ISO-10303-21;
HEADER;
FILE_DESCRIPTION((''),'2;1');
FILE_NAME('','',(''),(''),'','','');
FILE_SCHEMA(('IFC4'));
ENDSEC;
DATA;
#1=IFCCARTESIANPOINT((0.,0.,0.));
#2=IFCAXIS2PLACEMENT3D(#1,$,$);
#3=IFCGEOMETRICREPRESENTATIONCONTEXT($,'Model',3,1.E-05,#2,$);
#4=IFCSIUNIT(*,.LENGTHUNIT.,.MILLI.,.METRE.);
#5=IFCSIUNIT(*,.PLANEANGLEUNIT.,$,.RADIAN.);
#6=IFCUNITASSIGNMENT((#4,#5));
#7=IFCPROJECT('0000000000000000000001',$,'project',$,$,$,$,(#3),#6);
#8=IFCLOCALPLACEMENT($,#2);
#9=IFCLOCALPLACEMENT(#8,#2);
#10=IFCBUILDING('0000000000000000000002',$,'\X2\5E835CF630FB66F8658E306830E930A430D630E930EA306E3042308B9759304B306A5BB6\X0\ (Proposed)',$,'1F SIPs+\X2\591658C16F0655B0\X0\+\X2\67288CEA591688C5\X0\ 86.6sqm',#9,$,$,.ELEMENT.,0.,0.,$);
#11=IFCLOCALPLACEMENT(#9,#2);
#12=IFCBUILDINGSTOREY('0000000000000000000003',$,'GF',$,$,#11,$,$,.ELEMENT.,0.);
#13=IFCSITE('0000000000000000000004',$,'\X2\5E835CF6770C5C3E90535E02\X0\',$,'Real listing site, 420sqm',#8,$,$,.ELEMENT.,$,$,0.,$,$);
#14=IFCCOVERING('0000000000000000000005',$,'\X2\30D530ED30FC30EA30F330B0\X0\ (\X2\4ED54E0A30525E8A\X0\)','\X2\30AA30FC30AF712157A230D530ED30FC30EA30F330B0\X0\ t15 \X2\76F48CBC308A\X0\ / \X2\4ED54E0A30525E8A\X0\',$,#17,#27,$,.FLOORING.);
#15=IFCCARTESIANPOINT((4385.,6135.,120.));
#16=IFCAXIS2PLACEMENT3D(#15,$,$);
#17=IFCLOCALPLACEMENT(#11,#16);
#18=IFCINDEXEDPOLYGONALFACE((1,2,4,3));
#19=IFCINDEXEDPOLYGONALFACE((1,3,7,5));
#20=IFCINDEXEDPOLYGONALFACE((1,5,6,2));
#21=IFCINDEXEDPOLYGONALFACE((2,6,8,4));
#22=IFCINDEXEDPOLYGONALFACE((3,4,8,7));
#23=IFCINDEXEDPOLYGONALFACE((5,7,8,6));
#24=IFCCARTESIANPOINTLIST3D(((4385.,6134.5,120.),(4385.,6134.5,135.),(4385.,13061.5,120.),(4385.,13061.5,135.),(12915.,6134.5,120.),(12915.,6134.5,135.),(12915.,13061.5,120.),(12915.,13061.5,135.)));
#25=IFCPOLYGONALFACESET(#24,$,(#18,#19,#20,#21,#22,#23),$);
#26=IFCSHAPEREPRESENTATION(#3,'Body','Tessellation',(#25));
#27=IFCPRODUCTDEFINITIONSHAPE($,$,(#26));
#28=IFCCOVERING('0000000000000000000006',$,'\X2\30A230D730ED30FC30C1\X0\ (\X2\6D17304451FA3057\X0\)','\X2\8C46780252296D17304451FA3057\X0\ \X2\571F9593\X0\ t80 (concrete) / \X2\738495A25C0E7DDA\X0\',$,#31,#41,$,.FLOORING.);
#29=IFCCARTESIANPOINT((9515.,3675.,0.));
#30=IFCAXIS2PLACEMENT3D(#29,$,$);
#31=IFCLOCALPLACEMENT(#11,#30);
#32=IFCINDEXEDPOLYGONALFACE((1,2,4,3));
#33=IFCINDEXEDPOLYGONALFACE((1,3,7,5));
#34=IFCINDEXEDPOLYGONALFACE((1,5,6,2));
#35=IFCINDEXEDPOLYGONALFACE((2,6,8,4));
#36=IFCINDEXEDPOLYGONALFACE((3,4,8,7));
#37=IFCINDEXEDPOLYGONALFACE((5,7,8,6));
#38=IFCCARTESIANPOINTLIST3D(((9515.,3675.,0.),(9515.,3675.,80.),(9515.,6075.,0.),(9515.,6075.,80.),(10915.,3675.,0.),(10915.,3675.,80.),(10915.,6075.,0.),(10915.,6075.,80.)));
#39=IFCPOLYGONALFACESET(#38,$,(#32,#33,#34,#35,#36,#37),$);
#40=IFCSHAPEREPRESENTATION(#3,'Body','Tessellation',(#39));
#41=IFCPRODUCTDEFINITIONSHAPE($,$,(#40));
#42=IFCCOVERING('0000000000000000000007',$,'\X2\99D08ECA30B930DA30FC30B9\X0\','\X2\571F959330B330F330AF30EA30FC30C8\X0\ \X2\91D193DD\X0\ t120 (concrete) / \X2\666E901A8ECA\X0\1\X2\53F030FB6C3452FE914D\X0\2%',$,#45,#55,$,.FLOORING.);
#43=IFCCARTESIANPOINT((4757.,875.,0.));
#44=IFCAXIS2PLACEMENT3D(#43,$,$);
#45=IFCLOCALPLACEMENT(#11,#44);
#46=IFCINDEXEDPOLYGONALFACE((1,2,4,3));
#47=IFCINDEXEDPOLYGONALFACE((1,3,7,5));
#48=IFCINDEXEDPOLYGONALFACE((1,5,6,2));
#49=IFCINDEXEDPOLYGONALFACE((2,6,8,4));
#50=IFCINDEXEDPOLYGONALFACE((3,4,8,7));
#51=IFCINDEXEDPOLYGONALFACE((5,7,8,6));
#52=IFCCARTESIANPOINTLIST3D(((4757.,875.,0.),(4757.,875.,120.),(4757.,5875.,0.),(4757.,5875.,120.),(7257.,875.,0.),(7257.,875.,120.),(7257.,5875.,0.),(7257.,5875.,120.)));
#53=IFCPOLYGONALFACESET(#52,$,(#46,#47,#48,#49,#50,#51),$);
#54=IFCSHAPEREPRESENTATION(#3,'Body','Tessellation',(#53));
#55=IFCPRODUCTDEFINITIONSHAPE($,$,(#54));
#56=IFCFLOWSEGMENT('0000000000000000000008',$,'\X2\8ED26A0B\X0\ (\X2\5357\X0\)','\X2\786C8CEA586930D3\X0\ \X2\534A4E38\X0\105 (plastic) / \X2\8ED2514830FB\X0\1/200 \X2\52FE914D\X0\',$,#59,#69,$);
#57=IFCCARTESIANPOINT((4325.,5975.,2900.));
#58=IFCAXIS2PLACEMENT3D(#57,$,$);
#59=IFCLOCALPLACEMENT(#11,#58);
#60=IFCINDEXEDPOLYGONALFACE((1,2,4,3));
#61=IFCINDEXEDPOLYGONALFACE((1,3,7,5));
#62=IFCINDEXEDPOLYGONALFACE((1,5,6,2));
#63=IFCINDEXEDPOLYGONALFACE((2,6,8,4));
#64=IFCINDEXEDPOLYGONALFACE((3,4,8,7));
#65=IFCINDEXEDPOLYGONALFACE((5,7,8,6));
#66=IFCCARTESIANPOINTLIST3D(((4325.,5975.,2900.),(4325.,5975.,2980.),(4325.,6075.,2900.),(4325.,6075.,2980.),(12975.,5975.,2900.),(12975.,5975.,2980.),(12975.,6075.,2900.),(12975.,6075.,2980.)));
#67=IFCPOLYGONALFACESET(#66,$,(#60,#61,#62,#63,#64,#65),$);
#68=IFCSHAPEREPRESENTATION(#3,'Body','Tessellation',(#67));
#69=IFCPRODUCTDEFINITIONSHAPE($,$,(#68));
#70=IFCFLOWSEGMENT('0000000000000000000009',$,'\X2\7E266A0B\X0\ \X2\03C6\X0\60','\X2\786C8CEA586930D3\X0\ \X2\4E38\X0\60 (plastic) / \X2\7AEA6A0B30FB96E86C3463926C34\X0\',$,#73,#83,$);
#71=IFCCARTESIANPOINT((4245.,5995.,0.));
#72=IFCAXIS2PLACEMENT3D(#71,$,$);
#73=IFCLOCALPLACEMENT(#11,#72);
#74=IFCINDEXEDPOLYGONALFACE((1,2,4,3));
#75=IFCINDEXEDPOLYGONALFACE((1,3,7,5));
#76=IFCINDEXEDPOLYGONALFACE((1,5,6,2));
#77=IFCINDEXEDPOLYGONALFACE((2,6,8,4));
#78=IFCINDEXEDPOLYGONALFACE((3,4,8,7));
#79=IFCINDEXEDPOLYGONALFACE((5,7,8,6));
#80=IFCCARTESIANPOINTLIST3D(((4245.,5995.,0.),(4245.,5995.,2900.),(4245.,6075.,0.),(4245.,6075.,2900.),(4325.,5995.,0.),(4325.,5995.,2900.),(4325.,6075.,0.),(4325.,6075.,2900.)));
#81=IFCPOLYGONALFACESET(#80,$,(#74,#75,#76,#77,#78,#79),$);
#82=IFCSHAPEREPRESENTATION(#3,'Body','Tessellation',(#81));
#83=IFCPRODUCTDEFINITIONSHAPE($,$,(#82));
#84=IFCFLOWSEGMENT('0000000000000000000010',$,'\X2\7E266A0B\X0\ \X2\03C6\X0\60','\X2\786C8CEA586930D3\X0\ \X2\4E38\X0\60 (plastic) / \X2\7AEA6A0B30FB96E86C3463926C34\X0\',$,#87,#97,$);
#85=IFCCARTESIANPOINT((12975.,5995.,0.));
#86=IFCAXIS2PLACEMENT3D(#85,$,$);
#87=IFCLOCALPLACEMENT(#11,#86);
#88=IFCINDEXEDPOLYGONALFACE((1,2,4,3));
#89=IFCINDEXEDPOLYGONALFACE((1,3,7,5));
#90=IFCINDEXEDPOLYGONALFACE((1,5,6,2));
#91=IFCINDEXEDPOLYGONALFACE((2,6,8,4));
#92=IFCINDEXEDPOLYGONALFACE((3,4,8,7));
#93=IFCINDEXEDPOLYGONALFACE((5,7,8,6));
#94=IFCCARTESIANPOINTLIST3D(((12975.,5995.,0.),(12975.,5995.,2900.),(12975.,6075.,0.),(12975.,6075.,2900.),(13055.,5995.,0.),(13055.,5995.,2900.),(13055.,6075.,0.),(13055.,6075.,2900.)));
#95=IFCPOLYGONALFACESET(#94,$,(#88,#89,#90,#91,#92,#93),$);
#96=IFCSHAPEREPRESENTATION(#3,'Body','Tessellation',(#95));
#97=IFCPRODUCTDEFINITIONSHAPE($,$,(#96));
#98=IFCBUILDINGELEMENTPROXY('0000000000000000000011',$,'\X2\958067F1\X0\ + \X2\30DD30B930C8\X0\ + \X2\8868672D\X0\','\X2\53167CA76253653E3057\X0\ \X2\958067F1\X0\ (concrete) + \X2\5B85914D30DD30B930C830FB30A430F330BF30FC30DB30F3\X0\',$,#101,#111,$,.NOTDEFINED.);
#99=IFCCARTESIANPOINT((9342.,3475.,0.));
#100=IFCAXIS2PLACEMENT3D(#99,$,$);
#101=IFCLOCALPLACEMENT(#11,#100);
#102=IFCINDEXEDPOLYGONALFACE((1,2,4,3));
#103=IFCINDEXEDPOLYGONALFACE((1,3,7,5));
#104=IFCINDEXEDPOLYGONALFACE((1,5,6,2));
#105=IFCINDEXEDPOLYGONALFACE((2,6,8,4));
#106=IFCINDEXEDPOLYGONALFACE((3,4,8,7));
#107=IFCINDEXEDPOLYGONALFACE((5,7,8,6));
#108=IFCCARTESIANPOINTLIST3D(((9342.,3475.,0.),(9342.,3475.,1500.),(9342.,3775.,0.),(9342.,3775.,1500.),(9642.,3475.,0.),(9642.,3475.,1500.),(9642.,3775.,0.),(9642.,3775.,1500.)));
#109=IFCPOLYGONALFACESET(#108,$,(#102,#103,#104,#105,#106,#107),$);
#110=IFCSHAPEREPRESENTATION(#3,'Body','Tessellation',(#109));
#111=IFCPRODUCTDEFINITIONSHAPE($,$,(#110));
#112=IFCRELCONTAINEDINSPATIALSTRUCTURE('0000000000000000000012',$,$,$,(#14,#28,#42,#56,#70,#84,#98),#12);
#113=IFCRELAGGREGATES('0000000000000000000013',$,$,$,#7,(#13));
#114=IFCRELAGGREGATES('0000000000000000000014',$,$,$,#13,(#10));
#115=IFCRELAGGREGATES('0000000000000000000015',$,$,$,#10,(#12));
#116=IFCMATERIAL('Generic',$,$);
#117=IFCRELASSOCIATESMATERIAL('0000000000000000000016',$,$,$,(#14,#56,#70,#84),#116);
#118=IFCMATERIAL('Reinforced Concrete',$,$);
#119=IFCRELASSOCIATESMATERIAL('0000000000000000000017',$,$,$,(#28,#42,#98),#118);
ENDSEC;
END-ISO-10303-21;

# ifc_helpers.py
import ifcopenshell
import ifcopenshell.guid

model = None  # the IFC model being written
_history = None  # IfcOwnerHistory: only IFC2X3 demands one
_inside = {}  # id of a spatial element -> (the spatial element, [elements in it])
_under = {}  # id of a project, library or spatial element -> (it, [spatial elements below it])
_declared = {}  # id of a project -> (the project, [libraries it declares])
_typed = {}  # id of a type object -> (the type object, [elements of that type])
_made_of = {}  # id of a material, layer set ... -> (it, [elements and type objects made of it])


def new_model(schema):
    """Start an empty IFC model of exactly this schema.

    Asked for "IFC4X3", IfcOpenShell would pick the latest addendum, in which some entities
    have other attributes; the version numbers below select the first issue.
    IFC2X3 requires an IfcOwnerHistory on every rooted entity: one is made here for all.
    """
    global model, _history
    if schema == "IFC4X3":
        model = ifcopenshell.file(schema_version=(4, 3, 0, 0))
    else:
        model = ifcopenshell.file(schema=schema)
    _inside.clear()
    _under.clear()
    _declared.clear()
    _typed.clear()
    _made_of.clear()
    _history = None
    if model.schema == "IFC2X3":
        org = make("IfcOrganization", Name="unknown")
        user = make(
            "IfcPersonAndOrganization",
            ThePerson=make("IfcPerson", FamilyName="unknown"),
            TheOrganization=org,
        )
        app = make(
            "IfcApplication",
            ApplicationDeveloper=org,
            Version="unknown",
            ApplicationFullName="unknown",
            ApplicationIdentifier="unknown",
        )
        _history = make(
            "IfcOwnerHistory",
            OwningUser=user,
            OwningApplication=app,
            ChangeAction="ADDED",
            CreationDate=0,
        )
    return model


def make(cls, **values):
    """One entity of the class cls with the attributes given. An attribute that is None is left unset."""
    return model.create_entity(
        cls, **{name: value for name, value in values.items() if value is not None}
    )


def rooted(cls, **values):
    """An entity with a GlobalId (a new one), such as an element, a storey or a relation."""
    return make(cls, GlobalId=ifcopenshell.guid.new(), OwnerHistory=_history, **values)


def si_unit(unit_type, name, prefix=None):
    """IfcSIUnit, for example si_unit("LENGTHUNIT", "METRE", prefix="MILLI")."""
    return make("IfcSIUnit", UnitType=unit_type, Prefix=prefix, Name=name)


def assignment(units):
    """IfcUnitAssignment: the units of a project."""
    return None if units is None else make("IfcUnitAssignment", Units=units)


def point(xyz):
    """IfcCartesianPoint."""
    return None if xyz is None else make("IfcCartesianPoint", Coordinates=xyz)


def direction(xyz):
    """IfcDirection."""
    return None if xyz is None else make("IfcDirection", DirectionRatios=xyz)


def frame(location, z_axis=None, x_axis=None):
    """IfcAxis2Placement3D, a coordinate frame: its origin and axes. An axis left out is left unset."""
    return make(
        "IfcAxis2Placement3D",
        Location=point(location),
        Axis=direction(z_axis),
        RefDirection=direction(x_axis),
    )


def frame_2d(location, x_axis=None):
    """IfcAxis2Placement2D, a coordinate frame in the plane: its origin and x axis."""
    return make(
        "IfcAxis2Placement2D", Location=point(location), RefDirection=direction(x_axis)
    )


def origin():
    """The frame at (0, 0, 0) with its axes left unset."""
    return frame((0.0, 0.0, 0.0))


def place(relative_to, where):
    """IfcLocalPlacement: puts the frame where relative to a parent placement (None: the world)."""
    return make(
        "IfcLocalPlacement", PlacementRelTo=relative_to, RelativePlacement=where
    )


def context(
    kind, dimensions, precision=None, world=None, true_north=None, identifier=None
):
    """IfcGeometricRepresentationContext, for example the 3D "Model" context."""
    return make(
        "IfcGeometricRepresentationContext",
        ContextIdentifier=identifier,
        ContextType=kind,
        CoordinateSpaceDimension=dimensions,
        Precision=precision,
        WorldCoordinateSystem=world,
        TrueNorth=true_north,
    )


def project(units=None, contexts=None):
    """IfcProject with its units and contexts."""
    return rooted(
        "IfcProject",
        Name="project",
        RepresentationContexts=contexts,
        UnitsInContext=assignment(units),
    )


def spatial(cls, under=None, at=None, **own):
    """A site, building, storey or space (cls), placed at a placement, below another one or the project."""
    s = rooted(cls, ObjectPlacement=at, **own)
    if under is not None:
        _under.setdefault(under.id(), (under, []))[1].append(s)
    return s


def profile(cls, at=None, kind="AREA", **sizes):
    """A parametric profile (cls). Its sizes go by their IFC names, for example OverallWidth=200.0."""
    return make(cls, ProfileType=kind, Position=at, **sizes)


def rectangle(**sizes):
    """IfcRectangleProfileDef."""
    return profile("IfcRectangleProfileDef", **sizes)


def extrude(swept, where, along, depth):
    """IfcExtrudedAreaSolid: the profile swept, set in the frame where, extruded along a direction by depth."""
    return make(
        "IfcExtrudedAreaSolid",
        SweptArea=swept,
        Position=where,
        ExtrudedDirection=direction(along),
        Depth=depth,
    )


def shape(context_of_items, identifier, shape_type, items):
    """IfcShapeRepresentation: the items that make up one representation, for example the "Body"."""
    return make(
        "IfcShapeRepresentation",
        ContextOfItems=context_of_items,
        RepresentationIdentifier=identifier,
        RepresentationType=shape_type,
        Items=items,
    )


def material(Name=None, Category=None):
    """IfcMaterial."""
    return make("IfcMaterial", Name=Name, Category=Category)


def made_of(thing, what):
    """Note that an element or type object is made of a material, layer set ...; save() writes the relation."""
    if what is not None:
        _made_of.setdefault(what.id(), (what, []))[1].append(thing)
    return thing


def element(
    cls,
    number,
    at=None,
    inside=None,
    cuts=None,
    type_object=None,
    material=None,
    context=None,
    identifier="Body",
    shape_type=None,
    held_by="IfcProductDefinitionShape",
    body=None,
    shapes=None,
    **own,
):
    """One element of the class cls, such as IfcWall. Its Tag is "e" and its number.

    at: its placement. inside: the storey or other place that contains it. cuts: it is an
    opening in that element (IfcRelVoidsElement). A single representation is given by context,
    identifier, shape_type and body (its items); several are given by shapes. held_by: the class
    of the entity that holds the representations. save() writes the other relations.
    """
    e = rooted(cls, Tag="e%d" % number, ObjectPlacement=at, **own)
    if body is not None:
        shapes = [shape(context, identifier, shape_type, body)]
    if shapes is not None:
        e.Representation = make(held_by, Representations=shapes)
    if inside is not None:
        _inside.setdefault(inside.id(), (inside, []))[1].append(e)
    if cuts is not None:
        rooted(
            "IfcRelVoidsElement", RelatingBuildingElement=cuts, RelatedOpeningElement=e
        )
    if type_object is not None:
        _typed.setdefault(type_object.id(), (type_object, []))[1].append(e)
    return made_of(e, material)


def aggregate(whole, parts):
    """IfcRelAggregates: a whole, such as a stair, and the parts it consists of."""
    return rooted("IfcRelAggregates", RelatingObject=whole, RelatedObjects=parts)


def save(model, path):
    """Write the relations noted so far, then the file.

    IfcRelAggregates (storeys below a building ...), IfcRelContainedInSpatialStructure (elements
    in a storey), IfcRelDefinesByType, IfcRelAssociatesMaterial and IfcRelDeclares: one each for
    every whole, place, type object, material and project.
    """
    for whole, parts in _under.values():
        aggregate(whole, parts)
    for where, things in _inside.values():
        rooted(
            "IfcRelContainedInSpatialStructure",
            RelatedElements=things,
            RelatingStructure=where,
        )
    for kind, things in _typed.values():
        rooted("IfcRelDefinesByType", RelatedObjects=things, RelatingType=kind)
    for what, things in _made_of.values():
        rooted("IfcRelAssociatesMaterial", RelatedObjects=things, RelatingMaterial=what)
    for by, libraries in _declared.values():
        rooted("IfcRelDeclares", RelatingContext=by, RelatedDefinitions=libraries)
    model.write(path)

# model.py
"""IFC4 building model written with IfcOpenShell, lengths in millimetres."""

from ifc_helpers import new_model, si_unit, frame, frame_2d, origin, place, context, project, spatial, rectangle, extrude, material, element, save


model = new_model("IFC4")

# Units and contexts
model_context = context("Model", 3, precision=1e-05, world=origin())
ifc_project = project(units=[si_unit("LENGTHUNIT", "METRE", prefix="MILLI"), si_unit("PLANEANGLEUNIT", "RADIAN")], contexts=[model_context])

# Site, building, storey
site_placement = place(None, origin())
site = spatial("IfcSite", under=ifc_project, at=site_placement, Name="広島県尾道市", ObjectType="Real listing site, 420sqm", CompositionType="ELEMENT", RefElevation=0.0)
building_placement = place(site_placement, origin())
building = spatial("IfcBuilding", under=site, at=building_placement, Name="広島・書斎とライブラリのある静かな家 (Proposed)", ObjectType="1F SIPs+外壁漆喰+木質外装 86.6sqm", CompositionType="ELEMENT", ElevationOfRefHeight=0.0, ElevationOfTerrain=0.0)
storey_placement = place(building_placement, origin())
storey = spatial("IfcBuildingStorey", under=building, at=storey_placement, Name="GF", CompositionType="ELEMENT", Elevation=0.0)

# Shared definitions
ifc_material_1 = material(Name="Reinforced Concrete")

# Coverings
ifc_material_2 = material(Name="Generic")
covering_1_placement = place(storey_placement, frame((4385.0, 6135.0, 120.0)))
element("IfcCovering", 1, at=covering_1_placement, inside=storey, material=ifc_material_2, Name="フローリング (仕上げ床)", Description="オーク無垢フローリング t15 直貼り / 仕上げ床", PredefinedType="FLOORING", context=model_context, shape_type="SweptSolid", body=[
    extrude(rectangle(XDim=8530.0, YDim=6927.0, at=frame_2d((4265.0, 3463.0))), frame((4385.0, 6135.0, 120.0)), (0.0, 0.0, 1.0), 15.0),
])
covering_2_placement = place(storey_placement, frame((9515.0, 3675.0, 0.0)))
element("IfcCovering", 2, at=covering_2_placement, inside=storey, material=ifc_material_1, Name="アプローチ (洗い出し)", Description="豆砂利洗い出し 土間 t80 (concrete) / 玄関導線", PredefinedType="FLOORING", context=model_context, shape_type="SweptSolid", body=[
    extrude(rectangle(XDim=1400.0, YDim=2400.0, at=frame_2d((700.0, 1200.0))), frame((9515.0, 3675.0, 0.0)), (0.0, 0.0, 1.0), 80.0),
])
covering_3_placement = place(storey_placement, frame((4757.0, 875.0, 0.0)))
element("IfcCovering", 3, at=covering_3_placement, inside=storey, material=ifc_material_1, Name="駐車スペース", Description="土間コンクリート 金鏝 t120 (concrete) / 普通車1台・水勾配2%", PredefinedType="FLOORING", context=model_context, shape_type="SweptSolid", body=[
    extrude(rectangle(XDim=2500.0, YDim=5000.0, at=frame_2d((1250.0, 2500.0))), frame((4757.0, 875.0, 0.0)), (0.0, 0.0, 1.0), 120.0),
])

# Flow segments
flow_segment_1_placement = place(storey_placement, frame((4325.0, 5975.0, 2900.0)))
element("IfcFlowSegment", 4, at=flow_segment_1_placement, inside=storey, material=ifc_material_2, Name="軒樋 (南)", Description="硬質塩ビ 半丸105 (plastic) / 軒先・1/200 勾配", context=model_context, shape_type="SweptSolid", body=[
    extrude(rectangle(XDim=8650.0, YDim=100.0, at=frame_2d((4325.0, 50.0))), frame((4325.0, 5975.0, 2900.0)), (0.0, 0.0, 1.0), 80.0),
])
flow_segment_2_placement = place(storey_placement, frame((4245.0, 5995.0, 0.0)))
element("IfcFlowSegment", 5, at=flow_segment_2_placement, inside=storey, material=ifc_material_2, Name="縦樋 φ60", Description="硬質塩ビ 丸60 (plastic) / 竪樋・雨水排水", context=model_context, shape_type="SweptSolid", body=[
    extrude(rectangle(XDim=80.0, YDim=80.0, at=frame_2d((40.0, 40.0))), frame((4245.0, 5995.0, 0.0)), (0.0, 0.0, 1.0), 2900.0),
])
flow_segment_3_placement = place(storey_placement, frame((12975.0, 5995.0, 0.0)))
element("IfcFlowSegment", 6, at=flow_segment_3_placement, inside=storey, material=ifc_material_2, Name="縦樋 φ60", Description="硬質塩ビ 丸60 (plastic) / 竪樋・雨水排水", context=model_context, shape_type="SweptSolid", body=[
    extrude(rectangle(XDim=80.0, YDim=80.0, at=frame_2d((40.0, 40.0))), frame((12975.0, 5995.0, 0.0)), (0.0, 0.0, 1.0), 2900.0),
])

# Building element proxy
proxy_placement = place(storey_placement, frame((9342.0, 3475.0, 0.0)))
element("IfcBuildingElementProxy", 7, at=proxy_placement, inside=storey, material=ifc_material_1, Name="門柱 + ポスト + 表札", Description="化粧打放し 門柱 (concrete) + 宅配ポスト・インターホン", PredefinedType="NOTDEFINED", context=model_context, shape_type="SweptSolid", body=[
    extrude(rectangle(XDim=300.0, YDim=300.0, at=frame_2d((150.0, 150.0))), frame((9342.0, 3475.0, 0.0)), (0.0, 0.0, 1.0), 1500.0),
])

save(model, "model.ifc")
